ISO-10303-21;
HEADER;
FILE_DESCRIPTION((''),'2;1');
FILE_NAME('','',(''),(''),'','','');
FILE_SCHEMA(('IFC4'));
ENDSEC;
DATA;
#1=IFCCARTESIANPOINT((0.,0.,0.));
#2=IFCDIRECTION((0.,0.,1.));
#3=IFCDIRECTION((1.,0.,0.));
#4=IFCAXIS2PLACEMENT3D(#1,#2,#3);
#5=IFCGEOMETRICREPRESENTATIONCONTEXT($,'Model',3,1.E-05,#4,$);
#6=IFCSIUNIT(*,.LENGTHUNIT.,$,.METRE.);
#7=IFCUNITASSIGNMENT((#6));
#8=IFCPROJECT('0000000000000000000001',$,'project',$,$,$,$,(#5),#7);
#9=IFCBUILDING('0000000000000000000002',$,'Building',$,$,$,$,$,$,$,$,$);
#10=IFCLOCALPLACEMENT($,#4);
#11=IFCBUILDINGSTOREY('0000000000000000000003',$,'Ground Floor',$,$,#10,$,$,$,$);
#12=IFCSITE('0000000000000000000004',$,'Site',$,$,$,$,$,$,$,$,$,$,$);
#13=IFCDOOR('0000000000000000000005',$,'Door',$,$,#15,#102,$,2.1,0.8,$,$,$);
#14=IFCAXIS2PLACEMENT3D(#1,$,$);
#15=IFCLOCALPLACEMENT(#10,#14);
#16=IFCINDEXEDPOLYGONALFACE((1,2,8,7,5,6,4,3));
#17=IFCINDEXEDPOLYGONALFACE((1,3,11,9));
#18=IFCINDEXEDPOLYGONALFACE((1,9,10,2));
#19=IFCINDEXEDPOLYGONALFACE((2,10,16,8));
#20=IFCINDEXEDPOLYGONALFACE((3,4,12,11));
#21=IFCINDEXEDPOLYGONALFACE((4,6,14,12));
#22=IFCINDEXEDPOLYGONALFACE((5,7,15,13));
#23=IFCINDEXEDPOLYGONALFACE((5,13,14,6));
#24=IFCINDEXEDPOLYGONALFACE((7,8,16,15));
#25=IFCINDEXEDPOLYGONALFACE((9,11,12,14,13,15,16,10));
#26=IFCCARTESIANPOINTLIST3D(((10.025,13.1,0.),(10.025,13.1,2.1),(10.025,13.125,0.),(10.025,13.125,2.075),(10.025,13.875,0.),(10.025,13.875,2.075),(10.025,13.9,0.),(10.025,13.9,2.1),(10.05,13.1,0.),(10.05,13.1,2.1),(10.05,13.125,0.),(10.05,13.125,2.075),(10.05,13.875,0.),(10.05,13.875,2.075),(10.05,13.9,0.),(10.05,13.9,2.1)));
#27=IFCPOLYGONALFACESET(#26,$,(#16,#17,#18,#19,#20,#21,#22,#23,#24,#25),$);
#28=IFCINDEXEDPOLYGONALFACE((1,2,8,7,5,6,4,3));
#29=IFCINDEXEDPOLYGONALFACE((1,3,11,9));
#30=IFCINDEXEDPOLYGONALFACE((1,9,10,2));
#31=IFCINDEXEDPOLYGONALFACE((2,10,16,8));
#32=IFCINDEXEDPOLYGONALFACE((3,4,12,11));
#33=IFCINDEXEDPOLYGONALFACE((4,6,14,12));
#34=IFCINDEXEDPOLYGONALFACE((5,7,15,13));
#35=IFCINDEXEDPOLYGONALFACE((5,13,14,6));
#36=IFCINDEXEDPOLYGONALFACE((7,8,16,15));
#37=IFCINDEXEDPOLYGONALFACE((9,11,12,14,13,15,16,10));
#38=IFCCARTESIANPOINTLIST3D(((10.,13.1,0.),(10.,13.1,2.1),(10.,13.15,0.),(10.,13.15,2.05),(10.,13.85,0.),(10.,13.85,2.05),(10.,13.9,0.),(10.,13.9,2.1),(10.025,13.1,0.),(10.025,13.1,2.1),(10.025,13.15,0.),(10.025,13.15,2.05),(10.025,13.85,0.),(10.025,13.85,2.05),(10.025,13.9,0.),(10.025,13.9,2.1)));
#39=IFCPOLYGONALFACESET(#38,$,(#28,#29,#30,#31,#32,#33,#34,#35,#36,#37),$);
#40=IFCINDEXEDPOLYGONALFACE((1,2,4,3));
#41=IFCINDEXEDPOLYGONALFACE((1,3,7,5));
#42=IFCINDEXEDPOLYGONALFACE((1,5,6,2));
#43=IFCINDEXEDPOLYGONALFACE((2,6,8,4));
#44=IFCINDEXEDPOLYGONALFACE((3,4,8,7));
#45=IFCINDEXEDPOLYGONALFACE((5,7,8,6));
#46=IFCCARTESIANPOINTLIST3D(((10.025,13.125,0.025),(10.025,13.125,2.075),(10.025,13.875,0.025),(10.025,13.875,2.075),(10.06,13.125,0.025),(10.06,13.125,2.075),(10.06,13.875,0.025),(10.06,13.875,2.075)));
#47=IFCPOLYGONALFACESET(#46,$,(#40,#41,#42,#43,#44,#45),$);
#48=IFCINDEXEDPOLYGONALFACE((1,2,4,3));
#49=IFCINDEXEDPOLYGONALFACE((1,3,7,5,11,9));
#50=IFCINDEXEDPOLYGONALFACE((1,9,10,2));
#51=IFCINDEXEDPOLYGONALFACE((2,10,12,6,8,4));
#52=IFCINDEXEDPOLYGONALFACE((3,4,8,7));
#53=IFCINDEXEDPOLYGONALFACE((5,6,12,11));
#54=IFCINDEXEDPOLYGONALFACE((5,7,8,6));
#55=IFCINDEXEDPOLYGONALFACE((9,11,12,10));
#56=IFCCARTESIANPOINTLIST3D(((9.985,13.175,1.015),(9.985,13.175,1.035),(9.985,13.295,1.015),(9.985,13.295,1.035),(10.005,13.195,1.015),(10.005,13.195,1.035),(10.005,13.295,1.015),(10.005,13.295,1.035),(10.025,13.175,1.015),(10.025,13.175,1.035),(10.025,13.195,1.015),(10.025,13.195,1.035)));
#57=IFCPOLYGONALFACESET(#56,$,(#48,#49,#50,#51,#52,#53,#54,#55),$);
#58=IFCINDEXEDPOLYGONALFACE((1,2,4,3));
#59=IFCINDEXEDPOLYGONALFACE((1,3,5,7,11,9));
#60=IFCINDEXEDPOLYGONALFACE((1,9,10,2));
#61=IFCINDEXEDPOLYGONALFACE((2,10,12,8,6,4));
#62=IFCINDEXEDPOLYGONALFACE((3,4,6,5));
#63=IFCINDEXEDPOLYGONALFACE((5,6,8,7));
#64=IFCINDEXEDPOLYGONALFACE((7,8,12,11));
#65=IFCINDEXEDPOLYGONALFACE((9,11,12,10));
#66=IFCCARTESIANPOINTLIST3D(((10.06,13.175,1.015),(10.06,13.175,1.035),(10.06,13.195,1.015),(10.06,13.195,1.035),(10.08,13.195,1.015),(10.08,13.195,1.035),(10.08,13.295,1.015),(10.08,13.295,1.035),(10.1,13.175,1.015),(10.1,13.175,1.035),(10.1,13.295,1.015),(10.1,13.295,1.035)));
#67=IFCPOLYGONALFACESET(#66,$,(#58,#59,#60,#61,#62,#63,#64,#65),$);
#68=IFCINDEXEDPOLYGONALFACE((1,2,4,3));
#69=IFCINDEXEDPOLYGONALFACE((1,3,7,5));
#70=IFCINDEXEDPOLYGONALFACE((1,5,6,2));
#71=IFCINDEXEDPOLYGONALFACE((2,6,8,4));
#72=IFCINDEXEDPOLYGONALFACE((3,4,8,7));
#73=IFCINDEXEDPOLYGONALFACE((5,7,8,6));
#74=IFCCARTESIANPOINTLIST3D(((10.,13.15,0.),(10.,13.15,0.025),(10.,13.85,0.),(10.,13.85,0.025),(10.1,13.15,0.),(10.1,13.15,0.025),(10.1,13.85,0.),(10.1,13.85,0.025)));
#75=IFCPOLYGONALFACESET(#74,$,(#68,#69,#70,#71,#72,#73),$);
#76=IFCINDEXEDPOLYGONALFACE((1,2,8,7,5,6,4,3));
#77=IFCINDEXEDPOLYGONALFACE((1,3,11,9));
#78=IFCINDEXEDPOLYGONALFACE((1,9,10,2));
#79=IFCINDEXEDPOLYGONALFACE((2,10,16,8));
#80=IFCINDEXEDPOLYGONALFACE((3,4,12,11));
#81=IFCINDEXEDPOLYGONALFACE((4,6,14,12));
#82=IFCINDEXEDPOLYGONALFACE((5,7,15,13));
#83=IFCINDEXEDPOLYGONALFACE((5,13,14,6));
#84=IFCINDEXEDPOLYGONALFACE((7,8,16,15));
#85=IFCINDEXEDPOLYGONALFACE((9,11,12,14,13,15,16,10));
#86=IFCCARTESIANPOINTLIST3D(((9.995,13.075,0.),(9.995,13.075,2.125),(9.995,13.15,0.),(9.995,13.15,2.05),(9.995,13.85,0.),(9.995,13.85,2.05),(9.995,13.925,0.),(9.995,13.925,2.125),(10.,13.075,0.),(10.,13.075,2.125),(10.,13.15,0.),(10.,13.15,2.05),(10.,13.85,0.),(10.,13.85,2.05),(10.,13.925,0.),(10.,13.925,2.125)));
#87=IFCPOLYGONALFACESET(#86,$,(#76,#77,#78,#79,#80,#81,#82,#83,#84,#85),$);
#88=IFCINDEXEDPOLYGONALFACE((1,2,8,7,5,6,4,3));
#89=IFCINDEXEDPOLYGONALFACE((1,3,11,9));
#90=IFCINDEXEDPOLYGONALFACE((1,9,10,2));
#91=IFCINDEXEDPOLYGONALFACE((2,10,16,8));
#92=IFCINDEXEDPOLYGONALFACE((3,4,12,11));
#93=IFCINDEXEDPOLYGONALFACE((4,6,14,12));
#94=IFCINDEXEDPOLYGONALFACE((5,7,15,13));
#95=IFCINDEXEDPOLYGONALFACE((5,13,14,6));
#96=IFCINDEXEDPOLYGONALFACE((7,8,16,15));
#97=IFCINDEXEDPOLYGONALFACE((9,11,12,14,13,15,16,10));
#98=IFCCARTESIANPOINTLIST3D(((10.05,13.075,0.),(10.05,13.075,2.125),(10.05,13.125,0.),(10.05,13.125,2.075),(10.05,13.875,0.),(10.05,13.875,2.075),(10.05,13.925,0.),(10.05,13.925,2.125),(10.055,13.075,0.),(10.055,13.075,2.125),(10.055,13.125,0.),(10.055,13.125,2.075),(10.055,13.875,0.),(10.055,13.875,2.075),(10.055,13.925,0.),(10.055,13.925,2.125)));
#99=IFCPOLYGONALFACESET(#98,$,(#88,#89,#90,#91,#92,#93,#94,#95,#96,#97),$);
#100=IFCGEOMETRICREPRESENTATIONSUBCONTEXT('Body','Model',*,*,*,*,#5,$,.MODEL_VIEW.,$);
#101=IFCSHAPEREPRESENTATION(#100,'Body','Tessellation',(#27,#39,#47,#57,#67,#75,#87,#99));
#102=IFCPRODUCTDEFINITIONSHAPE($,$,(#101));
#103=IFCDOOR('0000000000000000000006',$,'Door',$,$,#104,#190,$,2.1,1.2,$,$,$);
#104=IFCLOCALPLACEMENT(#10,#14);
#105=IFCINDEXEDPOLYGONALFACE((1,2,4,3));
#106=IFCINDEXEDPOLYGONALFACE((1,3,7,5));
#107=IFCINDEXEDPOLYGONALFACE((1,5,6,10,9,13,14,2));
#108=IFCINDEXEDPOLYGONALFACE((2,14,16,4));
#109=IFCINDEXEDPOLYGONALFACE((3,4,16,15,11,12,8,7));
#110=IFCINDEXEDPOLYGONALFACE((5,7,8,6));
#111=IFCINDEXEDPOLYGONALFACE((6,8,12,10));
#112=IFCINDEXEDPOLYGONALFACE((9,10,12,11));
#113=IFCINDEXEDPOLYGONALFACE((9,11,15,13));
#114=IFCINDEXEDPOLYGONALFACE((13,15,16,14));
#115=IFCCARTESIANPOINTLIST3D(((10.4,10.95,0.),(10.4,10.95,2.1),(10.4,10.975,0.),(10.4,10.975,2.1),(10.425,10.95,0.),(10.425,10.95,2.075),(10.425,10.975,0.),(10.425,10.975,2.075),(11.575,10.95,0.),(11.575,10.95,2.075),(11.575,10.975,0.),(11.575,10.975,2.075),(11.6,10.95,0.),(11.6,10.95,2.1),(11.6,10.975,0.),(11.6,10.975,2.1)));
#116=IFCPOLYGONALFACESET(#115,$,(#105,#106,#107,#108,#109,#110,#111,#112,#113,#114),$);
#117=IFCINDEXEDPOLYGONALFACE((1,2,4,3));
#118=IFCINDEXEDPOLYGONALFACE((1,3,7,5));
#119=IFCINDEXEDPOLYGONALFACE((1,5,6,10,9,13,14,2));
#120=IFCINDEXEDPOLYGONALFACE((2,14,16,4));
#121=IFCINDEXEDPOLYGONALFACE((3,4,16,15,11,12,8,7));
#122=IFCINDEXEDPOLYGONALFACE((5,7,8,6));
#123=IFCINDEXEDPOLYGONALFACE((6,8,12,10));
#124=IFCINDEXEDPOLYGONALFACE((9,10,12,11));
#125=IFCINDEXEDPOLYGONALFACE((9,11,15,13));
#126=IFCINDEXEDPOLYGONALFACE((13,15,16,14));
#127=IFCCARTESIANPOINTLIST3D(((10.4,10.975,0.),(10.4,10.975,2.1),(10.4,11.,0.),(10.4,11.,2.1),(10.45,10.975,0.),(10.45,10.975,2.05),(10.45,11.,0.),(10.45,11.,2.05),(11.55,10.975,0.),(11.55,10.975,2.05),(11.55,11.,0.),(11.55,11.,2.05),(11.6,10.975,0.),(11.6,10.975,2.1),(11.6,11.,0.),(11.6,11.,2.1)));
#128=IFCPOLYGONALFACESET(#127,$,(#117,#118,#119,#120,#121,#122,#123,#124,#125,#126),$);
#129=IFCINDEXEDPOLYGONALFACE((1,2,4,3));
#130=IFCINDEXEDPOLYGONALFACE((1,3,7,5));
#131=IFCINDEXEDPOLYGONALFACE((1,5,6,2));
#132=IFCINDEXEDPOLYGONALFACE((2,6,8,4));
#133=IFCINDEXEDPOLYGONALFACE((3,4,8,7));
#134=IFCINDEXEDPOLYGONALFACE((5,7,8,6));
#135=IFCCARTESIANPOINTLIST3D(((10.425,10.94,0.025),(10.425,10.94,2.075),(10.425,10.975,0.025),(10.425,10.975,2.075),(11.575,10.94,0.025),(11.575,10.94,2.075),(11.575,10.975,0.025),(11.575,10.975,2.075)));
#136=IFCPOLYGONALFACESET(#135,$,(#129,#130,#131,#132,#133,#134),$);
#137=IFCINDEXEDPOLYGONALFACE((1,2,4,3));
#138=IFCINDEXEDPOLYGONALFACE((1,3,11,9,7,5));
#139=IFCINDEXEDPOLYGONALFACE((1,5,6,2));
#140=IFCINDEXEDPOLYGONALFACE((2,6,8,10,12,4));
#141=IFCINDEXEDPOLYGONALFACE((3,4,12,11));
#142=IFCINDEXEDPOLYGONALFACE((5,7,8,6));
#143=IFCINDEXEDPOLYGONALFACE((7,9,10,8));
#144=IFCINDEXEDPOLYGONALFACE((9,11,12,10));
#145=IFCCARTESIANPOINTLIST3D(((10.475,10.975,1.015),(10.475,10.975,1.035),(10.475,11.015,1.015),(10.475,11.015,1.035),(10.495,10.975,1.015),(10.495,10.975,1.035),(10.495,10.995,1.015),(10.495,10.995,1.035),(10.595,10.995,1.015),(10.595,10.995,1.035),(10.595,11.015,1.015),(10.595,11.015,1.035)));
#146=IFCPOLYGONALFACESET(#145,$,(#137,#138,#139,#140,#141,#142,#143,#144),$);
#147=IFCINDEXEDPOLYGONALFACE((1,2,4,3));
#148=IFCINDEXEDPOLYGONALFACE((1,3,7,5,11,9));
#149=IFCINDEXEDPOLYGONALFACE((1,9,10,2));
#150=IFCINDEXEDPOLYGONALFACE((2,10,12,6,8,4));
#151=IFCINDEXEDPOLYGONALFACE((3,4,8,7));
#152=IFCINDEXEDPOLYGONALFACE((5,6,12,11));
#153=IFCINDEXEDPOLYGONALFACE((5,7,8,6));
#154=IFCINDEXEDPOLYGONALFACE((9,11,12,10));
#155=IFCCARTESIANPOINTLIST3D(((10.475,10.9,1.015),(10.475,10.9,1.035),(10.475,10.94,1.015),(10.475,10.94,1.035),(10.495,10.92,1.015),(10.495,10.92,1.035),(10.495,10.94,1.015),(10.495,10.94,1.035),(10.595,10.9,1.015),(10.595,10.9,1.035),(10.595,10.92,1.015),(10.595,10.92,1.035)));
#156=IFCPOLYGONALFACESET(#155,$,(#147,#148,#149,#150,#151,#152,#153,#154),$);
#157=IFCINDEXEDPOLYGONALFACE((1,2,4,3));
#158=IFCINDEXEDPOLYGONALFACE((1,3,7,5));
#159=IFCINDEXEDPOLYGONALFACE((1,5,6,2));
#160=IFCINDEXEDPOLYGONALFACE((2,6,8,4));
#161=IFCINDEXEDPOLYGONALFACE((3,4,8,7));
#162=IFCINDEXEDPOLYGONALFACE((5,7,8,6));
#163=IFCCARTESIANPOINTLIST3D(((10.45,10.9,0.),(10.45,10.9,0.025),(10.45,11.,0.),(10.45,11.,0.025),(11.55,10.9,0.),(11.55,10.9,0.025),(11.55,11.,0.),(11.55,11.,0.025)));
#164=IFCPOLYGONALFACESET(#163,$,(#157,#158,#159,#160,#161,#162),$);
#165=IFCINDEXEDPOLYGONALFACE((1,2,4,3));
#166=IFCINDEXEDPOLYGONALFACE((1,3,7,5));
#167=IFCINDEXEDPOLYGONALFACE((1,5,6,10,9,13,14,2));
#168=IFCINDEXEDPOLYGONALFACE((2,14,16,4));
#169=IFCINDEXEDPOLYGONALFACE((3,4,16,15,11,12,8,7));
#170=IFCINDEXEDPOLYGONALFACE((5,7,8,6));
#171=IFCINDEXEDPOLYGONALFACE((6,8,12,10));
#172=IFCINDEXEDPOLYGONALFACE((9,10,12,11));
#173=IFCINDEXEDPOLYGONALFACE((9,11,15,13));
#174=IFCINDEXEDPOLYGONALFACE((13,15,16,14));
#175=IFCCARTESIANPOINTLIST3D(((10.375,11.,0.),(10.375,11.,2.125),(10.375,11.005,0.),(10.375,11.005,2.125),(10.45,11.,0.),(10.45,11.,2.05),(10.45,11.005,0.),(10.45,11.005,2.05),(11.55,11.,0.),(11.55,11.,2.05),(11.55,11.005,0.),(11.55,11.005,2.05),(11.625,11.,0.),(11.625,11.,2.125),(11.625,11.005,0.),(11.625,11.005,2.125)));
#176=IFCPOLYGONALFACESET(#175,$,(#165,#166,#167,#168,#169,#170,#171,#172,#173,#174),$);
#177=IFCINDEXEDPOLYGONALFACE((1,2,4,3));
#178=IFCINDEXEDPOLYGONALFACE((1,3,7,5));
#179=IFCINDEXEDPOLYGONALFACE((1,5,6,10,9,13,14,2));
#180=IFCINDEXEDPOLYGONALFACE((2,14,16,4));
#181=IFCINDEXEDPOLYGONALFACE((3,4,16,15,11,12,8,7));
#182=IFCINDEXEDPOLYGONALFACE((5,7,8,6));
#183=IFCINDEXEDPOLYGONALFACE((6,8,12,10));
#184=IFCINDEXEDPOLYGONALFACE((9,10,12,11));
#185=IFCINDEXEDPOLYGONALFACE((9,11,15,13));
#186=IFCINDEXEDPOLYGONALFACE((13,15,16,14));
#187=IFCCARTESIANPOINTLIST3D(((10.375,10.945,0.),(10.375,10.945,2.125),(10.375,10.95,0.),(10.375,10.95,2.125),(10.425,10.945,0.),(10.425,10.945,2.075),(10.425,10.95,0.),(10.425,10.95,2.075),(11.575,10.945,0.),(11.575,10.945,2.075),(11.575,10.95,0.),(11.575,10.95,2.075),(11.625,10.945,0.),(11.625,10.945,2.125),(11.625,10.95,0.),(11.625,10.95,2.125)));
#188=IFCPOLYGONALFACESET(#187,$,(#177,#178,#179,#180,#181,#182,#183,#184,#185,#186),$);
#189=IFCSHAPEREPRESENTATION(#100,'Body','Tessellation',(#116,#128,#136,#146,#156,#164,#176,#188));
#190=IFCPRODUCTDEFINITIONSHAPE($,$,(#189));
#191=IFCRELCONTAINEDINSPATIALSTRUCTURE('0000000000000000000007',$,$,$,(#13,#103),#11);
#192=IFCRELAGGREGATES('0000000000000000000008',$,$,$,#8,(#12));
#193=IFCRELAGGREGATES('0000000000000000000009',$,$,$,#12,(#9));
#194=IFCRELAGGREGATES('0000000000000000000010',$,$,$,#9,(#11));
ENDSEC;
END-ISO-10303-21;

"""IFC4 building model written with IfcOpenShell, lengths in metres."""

from ifc_helpers import new_model, si_unit, frame, origin_with_axes, place, context, subcontext, project, spatial, line, indexed_curve, outline, extrude, element, save


model = new_model("IFC4")

# Units and contexts
model_context = context("Model", 3, precision=1e-05, world=origin_with_axes())
body_context = subcontext(model_context, "Body", "Model", "MODEL_VIEW")
ifc_project = project(units=[si_unit("LENGTHUNIT", "METRE")], contexts=[model_context])

# Site, building, storey
site = spatial("IfcSite", under=ifc_project, Name="Site")
building = spatial("IfcBuilding", under=site, Name="Building")
storey_placement = place(None, origin_with_axes())
storey = spatial("IfcBuildingStorey", under=building, at=storey_placement, Name="Ground Floor")

# Doors
door_1_placement = place(storey_placement, frame((10.0, 13.9, 0.0), z_axis=(0.0, 0.0, 1.0), x_axis=(0.0, -1.0, 0.0)))
element("IfcDoor", 1, at=door_1_placement, inside=storey, Name="Door", OverallHeight=2.1, OverallWidth=0.8, context=body_context, shape_type="SweptSolid", body=[
    extrude(outline(indexed_curve([(0.0, 0.0), (0.0, 2.1), (0.8, 2.1), (0.8, 0.0), (0.775, 0.0), (0.775, 2.075), (0.025, 2.075), (0.025, 0.0)], segments=[line(1, 2, 3, 4, 5, 6, 7, 8, 1)])), frame((0.0, 0.025, 0.0), z_axis=(0.0, -1.0, 0.0), x_axis=(1.0, 0.0, 0.0)), (0.0, 0.0, -1.0), 0.025),
    extrude(outline(indexed_curve([(0.0, 0.0), (0.0, 2.1), (0.8, 2.1), (0.8, 0.0), (0.75, 0.0), (0.75, 2.05), (0.05, 2.05), (0.05, 0.0)], segments=[line(1, 2, 3, 4, 5, 6, 7, 8, 1)])), frame((0.0, 0.0, 0.0), z_axis=(0.0, -1.0, 0.0), x_axis=(1.0, 0.0, 0.0)), (0.0, 0.0, -1.0), 0.025),
    extrude(outline(indexed_curve([(0.0, 0.0), (0.75, 0.0), (0.75, 0.035), (0.0, 0.035)], segments=[line(1, 2, 3, 4, 1)])), frame((0.025, 0.025, 0.025), z_axis=(0.0, 0.0, 1.0), x_axis=(1.0, 0.0, 0.0)), (0.0, 0.0, 1.0), 2.05),
    extrude(outline(indexed_curve([(0.0, 0.0), (0.0, -0.04), (-0.12, -0.04), (-0.12, -0.02), (-0.02, -0.02), (-0.02, 0.0)], segments=[line(1, 2, 3, 4, 5, 6, 1)])), frame((0.725, 0.025, 1.015), z_axis=(0.0, 0.0, 1.0), x_axis=(1.0, 0.0, 0.0)), (0.0, 0.0, 1.0), 0.02),
    extrude(outline(indexed_curve([(0.0, 0.0), (0.0, 0.04), (-0.12, 0.04), (-0.12, 0.02), (-0.02, 0.02), (-0.02, 0.0)], segments=[line(1, 2, 3, 4, 5, 6, 1)])), frame((0.725, 0.06, 1.015), z_axis=(0.0, 0.0, 1.0), x_axis=(1.0, 0.0, 0.0)), (0.0, 0.0, 1.0), 0.02),
    extrude(outline(indexed_curve([(0.0, 0.0), (0.7, 0.0), (0.7, 0.1), (0.0, 0.1)], segments=[line(1, 2, 3, 4, 1)])), frame((0.05, 0.0, 0.0), z_axis=(0.0, 0.0, 1.0), x_axis=(1.0, 0.0, 0.0)), (0.0, 0.0, 1.0), 0.025),
    extrude(outline(indexed_curve([(0.0, 0.0), (0.0, 2.125), (0.85, 2.125), (0.85, 0.0), (0.775, 0.0), (0.775, 2.05), (0.075, 2.05), (0.075, 0.0)], segments=[line(1, 2, 3, 4, 5, 6, 7, 8, 1)])), frame((-0.025, -0.005, 0.0), z_axis=(0.0, -1.0, 0.0), x_axis=(1.0, 0.0, 0.0)), (0.0, 0.0, -1.0), 0.005),
    extrude(outline(indexed_curve([(0.0, 0.0), (0.0, 2.125), (0.85, 2.125), (0.85, 0.0), (0.8, 0.0), (0.8, 2.075), (0.05, 2.075), (0.05, 0.0)], segments=[line(1, 2, 3, 4, 5, 6, 7, 8, 1)])), frame((-0.025, 0.05, 0.0), z_axis=(0.0, -1.0, 0.0), x_axis=(1.0, 0.0, 0.0)), (0.0, 0.0, -1.0), 0.005),
])
door_2_placement = place(storey_placement, frame((11.6, 11.0, 0.0), z_axis=(0.0, 0.0, 1.0), x_axis=(-1.0, 0.0, 0.0)))
element("IfcDoor", 2, at=door_2_placement, inside=storey, Name="Door", OverallHeight=2.1, OverallWidth=1.2, context=body_context, shape_type="SweptSolid", body=[
    extrude(outline(indexed_curve([(0.0, 0.0), (0.0, 2.1), (1.2, 2.1), (1.2, 0.0), (1.175, 0.0), (1.175, 2.075), (0.025, 2.075), (0.025, 0.0)], segments=[line(1, 2, 3, 4, 5, 6, 7, 8, 1)])), frame((0.0, 0.025, 0.0), z_axis=(0.0, -1.0, 0.0), x_axis=(1.0, 0.0, 0.0)), (0.0, 0.0, -1.0), 0.025),
    extrude(outline(indexed_curve([(0.0, 0.0), (0.0, 2.1), (1.2, 2.1), (1.2, 0.0), (1.15, 0.0), (1.15, 2.05), (0.05, 2.05), (0.05, 0.0)], segments=[line(1, 2, 3, 4, 5, 6, 7, 8, 1)])), frame((0.0, 0.0, 0.0), z_axis=(0.0, -1.0, 0.0), x_axis=(1.0, 0.0, 0.0)), (0.0, 0.0, -1.0), 0.025),
    extrude(outline(indexed_curve([(0.0, 0.0), (1.15, 0.0), (1.15, 0.035), (0.0, 0.035)], segments=[line(1, 2, 3, 4, 1)])), frame((0.025, 0.025, 0.025), z_axis=(0.0, 0.0, 1.0), x_axis=(1.0, 0.0, 0.0)), (0.0, 0.0, 1.0), 2.05),
    extrude(outline(indexed_curve([(0.0, 0.0), (0.0, -0.04), (-0.12, -0.04), (-0.12, -0.02), (-0.02, -0.02), (-0.02, 0.0)], segments=[line(1, 2, 3, 4, 5, 6, 1)])), frame((1.125, 0.025, 1.015), z_axis=(0.0, 0.0, 1.0), x_axis=(1.0, 0.0, 0.0)), (0.0, 0.0, 1.0), 0.02),
    extrude(outline(indexed_curve([(0.0, 0.0), (0.0, 0.04), (-0.12, 0.04), (-0.12, 0.02), (-0.02, 0.02), (-0.02, 0.0)], segments=[line(1, 2, 3, 4, 5, 6, 1)])), frame((1.125, 0.06, 1.015), z_axis=(0.0, 0.0, 1.0), x_axis=(1.0, 0.0, 0.0)), (0.0, 0.0, 1.0), 0.02),
    extrude(outline(indexed_curve([(0.0, 0.0), (1.1, 0.0), (1.1, 0.1), (0.0, 0.1)], segments=[line(1, 2, 3, 4, 1)])), frame((0.05, 0.0, 0.0), z_axis=(0.0, 0.0, 1.0), x_axis=(1.0, 0.0, 0.0)), (0.0, 0.0, 1.0), 0.025),
    extrude(outline(indexed_curve([(0.0, 0.0), (0.0, 2.125), (1.25, 2.125), (1.25, 0.0), (1.175, 0.0), (1.175, 2.05), (0.075, 2.05), (0.075, 0.0)], segments=[line(1, 2, 3, 4, 5, 6, 7, 8, 1)])), frame((-0.025, -0.005, 0.0), z_axis=(0.0, -1.0, 0.0), x_axis=(1.0, 0.0, 0.0)), (0.0, 0.0, -1.0), 0.005),
    extrude(outline(indexed_curve([(0.0, 0.0), (0.0, 2.125), (1.25, 2.125), (1.25, 0.0), (1.2, 0.0), (1.2, 2.075), (0.05, 2.075), (0.05, 0.0)], segments=[line(1, 2, 3, 4, 5, 6, 7, 8, 1)])), frame((-0.025, 0.05, 0.0), z_axis=(0.0, -1.0, 0.0), x_axis=(1.0, 0.0, 0.0)), (0.0, 0.0, -1.0), 0.005),
])

save(model, "model.ifc")
